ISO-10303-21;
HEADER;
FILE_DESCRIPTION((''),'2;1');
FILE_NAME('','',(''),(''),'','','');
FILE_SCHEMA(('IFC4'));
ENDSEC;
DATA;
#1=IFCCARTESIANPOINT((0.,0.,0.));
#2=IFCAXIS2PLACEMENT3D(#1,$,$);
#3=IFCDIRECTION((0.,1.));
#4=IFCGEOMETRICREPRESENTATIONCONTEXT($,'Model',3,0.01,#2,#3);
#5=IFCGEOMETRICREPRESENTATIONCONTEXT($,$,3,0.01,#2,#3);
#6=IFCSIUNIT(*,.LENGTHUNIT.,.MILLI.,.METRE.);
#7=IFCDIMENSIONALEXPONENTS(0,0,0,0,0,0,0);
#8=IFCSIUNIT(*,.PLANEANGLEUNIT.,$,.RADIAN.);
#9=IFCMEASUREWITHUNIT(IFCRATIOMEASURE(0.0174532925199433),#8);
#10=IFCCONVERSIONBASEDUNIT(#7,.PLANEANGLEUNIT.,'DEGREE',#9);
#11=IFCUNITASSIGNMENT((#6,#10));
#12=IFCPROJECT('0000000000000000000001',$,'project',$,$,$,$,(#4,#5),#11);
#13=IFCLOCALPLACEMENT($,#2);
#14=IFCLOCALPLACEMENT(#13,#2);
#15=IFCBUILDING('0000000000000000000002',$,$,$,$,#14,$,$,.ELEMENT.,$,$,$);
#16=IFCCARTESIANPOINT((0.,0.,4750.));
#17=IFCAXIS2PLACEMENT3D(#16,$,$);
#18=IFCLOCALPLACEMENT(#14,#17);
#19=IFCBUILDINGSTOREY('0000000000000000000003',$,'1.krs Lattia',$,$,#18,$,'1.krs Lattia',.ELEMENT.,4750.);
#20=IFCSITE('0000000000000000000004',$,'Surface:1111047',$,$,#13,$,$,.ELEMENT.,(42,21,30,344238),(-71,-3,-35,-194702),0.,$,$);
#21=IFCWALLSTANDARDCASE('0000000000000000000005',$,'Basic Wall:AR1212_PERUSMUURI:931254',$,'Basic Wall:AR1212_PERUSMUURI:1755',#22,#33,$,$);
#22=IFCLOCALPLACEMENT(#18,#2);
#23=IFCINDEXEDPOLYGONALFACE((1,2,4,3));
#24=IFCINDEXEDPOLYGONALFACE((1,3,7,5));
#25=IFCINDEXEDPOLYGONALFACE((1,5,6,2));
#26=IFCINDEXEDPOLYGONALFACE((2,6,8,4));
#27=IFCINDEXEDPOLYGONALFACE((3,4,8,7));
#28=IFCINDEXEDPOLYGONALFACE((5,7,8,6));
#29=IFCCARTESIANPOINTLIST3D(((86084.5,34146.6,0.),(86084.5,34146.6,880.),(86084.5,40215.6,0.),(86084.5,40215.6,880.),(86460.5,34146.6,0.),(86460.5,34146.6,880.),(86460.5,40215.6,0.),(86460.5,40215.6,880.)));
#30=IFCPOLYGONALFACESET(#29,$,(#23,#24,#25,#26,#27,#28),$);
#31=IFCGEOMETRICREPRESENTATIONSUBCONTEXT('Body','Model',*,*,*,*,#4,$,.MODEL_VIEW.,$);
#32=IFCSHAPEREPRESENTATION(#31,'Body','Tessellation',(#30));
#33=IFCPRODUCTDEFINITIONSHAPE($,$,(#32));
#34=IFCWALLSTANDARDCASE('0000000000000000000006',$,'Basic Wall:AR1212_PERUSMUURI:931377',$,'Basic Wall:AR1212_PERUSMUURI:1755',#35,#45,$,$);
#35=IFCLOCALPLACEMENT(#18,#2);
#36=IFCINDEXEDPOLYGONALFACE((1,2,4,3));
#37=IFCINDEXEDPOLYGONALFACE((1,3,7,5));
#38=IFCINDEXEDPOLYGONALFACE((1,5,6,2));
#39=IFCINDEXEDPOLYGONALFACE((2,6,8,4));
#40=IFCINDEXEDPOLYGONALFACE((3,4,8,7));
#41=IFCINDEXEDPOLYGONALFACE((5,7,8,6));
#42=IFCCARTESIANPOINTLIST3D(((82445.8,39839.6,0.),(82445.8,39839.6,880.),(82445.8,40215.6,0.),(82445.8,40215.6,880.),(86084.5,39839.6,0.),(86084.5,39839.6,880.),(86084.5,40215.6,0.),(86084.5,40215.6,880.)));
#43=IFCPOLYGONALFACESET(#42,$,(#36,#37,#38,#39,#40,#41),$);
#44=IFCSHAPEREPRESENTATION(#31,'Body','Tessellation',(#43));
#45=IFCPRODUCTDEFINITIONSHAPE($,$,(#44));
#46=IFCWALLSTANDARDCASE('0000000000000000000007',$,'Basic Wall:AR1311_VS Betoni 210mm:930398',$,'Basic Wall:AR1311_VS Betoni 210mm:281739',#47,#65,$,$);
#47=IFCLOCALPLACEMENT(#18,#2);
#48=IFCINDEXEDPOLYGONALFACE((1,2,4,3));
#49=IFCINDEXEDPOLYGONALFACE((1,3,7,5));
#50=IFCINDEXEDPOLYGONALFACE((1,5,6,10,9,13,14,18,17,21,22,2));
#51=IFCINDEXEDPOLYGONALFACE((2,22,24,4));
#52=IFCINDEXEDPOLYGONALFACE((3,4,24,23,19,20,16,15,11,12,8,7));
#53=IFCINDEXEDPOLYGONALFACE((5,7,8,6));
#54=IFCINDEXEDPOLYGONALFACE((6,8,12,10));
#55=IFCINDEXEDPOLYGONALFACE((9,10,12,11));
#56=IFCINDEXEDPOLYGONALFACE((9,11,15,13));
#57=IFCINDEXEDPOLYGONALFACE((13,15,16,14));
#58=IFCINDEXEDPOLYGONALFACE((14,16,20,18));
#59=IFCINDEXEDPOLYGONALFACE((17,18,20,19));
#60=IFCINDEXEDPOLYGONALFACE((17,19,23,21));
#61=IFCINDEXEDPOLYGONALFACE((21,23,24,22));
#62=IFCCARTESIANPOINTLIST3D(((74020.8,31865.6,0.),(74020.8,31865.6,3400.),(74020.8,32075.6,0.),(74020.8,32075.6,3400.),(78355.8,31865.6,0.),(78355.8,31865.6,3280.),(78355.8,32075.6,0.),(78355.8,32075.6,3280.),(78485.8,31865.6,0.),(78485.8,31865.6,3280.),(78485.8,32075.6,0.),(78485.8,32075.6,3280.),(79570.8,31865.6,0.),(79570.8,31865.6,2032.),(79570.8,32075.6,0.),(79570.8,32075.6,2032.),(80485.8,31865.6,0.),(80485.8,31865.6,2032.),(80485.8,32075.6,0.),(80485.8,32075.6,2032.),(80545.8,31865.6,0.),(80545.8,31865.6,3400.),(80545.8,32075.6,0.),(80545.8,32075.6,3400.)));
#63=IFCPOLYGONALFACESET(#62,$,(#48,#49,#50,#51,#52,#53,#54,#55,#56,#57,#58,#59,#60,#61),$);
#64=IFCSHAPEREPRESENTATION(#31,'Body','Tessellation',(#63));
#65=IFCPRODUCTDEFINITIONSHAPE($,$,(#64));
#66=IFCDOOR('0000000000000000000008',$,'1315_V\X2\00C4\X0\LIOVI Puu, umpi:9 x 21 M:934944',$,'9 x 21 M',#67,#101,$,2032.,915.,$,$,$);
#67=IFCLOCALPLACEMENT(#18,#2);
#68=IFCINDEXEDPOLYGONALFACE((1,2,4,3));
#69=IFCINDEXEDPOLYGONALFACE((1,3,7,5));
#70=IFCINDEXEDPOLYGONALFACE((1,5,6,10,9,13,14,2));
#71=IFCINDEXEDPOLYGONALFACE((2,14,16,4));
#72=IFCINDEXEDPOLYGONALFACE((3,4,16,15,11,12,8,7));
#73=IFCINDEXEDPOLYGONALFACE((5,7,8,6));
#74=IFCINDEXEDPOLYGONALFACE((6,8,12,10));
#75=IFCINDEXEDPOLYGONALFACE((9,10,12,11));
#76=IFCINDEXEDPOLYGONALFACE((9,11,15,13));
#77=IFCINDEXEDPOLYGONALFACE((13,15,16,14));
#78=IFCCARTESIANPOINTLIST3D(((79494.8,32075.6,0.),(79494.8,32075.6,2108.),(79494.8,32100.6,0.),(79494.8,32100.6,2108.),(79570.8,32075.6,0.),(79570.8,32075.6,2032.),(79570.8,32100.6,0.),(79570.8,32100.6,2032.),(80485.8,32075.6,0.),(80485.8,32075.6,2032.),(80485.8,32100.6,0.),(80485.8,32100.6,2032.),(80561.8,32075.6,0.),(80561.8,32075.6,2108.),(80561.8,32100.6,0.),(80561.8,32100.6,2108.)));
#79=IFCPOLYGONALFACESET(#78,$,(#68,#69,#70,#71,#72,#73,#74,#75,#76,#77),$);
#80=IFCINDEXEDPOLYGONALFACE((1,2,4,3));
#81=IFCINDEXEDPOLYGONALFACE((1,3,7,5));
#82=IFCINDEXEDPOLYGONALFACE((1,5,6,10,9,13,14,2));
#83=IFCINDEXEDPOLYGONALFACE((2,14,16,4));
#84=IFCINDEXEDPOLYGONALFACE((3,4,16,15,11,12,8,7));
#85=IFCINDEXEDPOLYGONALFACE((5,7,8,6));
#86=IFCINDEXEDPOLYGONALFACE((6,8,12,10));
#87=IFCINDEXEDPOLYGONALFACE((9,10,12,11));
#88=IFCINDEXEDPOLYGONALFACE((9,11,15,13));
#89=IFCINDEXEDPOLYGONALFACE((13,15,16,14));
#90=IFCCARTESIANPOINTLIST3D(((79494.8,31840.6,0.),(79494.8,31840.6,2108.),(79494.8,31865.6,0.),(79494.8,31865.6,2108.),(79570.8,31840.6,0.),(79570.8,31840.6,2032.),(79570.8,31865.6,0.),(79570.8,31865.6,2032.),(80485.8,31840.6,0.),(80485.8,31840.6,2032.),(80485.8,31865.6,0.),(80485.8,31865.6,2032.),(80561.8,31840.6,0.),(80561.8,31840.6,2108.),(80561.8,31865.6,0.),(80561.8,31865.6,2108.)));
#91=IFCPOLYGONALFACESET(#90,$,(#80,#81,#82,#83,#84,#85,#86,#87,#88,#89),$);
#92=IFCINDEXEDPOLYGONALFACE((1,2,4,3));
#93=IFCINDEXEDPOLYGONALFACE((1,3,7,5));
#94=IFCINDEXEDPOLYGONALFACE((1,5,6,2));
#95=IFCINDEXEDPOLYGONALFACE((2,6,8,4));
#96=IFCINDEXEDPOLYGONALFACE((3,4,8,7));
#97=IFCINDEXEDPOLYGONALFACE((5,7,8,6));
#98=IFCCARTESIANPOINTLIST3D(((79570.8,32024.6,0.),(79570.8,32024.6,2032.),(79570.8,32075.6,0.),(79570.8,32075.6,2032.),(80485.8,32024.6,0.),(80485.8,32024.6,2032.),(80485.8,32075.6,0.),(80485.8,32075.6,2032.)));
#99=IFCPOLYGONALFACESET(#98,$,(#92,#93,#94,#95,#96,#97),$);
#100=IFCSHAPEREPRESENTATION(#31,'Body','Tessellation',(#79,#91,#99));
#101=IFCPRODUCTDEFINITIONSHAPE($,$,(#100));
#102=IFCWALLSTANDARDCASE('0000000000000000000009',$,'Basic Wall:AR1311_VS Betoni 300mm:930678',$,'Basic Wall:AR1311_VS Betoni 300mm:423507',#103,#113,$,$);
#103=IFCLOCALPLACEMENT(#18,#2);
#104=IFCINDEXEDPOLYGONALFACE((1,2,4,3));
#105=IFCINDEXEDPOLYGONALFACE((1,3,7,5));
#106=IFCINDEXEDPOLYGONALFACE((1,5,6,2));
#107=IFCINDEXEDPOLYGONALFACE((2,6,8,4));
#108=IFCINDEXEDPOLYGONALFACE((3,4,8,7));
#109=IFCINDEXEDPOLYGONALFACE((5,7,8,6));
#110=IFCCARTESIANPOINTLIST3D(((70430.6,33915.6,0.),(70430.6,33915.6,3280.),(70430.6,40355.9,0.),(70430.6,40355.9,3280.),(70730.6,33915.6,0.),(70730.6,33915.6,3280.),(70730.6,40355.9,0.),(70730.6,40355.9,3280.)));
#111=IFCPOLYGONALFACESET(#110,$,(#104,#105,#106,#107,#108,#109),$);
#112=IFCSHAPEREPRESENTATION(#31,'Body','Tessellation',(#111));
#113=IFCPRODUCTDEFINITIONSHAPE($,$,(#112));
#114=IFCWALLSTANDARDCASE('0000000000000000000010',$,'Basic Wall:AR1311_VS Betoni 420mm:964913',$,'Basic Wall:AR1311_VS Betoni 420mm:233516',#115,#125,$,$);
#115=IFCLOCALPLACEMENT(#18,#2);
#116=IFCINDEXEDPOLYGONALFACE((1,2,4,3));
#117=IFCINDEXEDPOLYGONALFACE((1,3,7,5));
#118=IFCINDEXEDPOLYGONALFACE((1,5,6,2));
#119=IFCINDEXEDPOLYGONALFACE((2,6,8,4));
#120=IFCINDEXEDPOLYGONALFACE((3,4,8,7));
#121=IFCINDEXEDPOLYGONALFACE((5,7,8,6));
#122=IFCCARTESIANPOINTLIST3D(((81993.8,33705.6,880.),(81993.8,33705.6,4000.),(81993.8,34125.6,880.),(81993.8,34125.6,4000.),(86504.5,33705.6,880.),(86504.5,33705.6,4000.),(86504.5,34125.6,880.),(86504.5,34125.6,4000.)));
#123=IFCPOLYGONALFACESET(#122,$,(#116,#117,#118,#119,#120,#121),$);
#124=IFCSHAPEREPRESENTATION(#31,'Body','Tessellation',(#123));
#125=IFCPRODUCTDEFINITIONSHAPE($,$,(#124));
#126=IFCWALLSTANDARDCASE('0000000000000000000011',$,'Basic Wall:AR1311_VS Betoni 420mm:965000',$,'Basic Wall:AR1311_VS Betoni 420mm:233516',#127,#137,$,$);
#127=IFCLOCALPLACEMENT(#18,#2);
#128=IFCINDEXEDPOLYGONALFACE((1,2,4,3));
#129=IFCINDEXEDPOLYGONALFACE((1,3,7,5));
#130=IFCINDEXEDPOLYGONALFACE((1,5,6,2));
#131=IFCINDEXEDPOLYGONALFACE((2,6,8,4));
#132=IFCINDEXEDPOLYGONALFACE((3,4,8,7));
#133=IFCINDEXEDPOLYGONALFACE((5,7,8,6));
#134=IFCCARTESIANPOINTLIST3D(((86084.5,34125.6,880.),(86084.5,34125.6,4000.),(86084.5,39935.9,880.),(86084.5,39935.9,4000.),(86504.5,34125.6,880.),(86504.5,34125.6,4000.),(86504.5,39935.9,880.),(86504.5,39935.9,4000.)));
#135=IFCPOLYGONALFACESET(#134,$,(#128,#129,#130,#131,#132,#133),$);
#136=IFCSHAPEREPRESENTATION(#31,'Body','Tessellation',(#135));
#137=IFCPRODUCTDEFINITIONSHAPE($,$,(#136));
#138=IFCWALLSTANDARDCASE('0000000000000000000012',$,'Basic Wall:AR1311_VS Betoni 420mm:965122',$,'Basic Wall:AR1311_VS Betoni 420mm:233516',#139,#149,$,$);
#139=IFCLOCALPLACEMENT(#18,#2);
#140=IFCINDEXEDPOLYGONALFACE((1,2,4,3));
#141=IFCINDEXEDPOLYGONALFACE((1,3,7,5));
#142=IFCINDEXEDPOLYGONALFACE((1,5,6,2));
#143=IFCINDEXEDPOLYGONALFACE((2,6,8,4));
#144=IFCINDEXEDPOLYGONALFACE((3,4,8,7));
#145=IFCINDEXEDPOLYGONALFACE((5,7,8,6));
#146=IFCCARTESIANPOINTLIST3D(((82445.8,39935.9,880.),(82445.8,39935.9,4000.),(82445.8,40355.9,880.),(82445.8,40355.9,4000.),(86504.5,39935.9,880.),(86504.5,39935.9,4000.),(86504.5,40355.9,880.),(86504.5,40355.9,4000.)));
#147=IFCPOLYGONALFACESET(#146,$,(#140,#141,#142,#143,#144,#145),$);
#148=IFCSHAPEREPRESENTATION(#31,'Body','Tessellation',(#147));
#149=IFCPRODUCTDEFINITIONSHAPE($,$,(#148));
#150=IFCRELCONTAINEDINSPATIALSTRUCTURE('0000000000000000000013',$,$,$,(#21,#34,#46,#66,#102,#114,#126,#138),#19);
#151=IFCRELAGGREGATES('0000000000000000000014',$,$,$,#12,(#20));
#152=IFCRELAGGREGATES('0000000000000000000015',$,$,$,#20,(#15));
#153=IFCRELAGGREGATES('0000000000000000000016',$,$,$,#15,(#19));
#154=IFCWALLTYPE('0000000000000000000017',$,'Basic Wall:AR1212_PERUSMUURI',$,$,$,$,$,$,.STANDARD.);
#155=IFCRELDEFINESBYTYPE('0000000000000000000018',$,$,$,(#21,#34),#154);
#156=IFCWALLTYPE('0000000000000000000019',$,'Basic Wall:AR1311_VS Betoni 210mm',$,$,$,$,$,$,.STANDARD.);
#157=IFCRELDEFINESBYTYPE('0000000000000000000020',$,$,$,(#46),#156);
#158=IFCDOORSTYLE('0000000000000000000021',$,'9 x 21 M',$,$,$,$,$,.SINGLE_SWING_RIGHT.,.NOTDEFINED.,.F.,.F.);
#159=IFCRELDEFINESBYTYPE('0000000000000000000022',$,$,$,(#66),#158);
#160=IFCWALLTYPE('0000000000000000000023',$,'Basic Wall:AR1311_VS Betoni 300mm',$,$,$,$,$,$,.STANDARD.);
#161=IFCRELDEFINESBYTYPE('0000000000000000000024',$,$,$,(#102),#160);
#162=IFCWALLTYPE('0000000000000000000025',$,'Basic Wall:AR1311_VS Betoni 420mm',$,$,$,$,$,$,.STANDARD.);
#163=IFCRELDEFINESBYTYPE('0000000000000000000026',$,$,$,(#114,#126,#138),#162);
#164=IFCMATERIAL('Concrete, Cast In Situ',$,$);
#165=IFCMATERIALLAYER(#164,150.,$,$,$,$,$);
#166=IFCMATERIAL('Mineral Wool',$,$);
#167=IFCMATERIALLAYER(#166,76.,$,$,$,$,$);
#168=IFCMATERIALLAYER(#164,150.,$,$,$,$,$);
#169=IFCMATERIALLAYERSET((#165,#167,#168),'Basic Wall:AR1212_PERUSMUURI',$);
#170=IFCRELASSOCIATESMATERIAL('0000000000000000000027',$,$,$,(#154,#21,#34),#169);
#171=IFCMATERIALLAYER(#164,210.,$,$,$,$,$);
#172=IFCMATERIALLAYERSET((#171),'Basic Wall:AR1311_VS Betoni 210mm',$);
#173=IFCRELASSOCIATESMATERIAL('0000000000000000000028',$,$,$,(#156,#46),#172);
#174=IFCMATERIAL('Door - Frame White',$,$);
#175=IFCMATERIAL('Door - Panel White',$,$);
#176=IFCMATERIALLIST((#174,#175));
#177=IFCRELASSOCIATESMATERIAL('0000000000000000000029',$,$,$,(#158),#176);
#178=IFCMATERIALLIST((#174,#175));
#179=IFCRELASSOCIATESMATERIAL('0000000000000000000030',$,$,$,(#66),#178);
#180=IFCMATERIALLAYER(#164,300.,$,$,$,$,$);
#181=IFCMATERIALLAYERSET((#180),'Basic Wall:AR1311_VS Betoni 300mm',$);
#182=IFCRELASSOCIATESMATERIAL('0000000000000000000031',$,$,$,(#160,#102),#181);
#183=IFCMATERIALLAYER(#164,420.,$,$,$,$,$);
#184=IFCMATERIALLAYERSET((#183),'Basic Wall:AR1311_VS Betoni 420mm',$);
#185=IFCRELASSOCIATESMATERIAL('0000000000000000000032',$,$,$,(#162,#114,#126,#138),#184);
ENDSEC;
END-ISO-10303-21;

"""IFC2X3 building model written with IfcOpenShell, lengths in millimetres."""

from ifc_helpers import new_model, entity, si_unit, converted_unit, direction, frame, frame_2d, origin, place, context, subcontext, project, spatial, polyline, rectangle, outline, extrude, clip, bounded_halfspace, source, transform, mapped, material, material_list, layer, layer_set, layer_usage, type_object, type_shapes, element, fill, save


model = new_model("IFC2X3")

# Units and contexts
model_context = context("Model", 3, precision=0.01, world=origin(), true_north=direction((0.0, 1.0)))
context_of_model = context(None, 3, precision=0.01, world=origin(), true_north=direction((0.0, 1.0)))
body_context = subcontext(model_context, "Body", "Model", "MODEL_VIEW")
ifc_project = project(units=[si_unit("LENGTHUNIT", "METRE", prefix="MILLI"), converted_unit("PLANEANGLEUNIT", "DEGREE", entity("IfcRatioMeasure", 0.0174532925199433), si_unit("PLANEANGLEUNIT", "RADIAN"), dimensions=[0, 0, 0, 0, 0, 0, 0])], contexts=[model_context, context_of_model])

# Site, building, storey
site_placement = place(None, origin())
site = spatial("IfcSite", under=ifc_project, at=site_placement, Name="Surface:1111047", CompositionType="ELEMENT", RefLatitude=(42, 21, 30, 344238), RefLongitude=(-71, -3, -35, -194702), RefElevation=0.0)
building_placement = place(site_placement, origin())
building = spatial("IfcBuilding", under=site, at=building_placement, CompositionType="ELEMENT")
storey_placement = place(building_placement, frame((0.0, 0.0, 4750.0)))
storey = spatial("IfcBuildingStorey", under=building, at=storey_placement, Name="1.krs Lattia", LongName="1.krs Lattia", CompositionType="ELEMENT", Elevation=4750.0)

# Walls
ifc_material_1 = material(Name="Concrete, Cast In Situ")
ifc_layer_1 = layer(ifc_material_1, 150.0)
ifc_material_2 = material(Name="Mineral Wool")
ifc_layer_2 = layer(ifc_material_2, 76.0)
ifc_layer_3 = layer(ifc_material_1, 150.0)
ifc_layer_set_1 = layer_set([ifc_layer_1, ifc_layer_2, ifc_layer_3], Name="Basic Wall:AR1212_PERUSMUURI")
wall_type_1 = type_object("IfcWallType", Name="Basic Wall:AR1212_PERUSMUURI", PredefinedType="STANDARD", material=ifc_layer_set_1)
ifc_layer_usage_1 = layer_usage(ifc_layer_set_1, "AXIS2", "NEGATIVE", 188.0)
wall_1_placement = place(storey_placement, frame((86272.5, 34146.6, 0.0), z_axis=(0.0, 0.0, 1.0), x_axis=(0.0, 1.0, 0.0)))
element("IfcWallStandardCase", 1, at=wall_1_placement, inside=storey, type_object=wall_type_1, material=ifc_layer_usage_1, Name="Basic Wall:AR1212_PERUSMUURI:931254", ObjectType="Basic Wall:AR1212_PERUSMUURI:1755", context=body_context, shape_type="SweptSolid", body=[
    extrude(rectangle(XDim=6069.0, YDim=376.0, at=frame_2d((3034.5, 0.0), x_axis=(-1.0, 0.0))), origin(), (0.0, 0.0, 1.0), 880.0),
])
ifc_layer_usage_2 = layer_usage(ifc_layer_set_1, "AXIS2", "NEGATIVE", 188.0)
wall_2_placement = place(storey_placement, frame((86084.5, 40027.6, 0.0), z_axis=(0.0, 0.0, 1.0), x_axis=(-1.0, 0.0, 0.0)))
element("IfcWallStandardCase", 2, at=wall_2_placement, inside=storey, type_object=wall_type_1, material=ifc_layer_usage_2, Name="Basic Wall:AR1212_PERUSMUURI:931377", ObjectType="Basic Wall:AR1212_PERUSMUURI:1755", context=body_context, shape_type="SweptSolid", body=[
    extrude(rectangle(XDim=3638.7, YDim=376.0, at=frame_2d((1819.3, 0.0), x_axis=(-1.0, 0.0))), origin(), (0.0, 0.0, 1.0), 880.0),
])

# Wall, opening, door
ifc_layer_4 = layer(ifc_material_1, 210.0)
ifc_layer_set_2 = layer_set([ifc_layer_4], Name="Basic Wall:AR1311_VS Betoni 210mm")
ifc_layer_usage_3 = layer_usage(ifc_layer_set_2, "AXIS2", "NEGATIVE", 105.0)
wall_type_2 = type_object("IfcWallType", Name="Basic Wall:AR1311_VS Betoni 210mm", PredefinedType="STANDARD", material=ifc_layer_set_2)
wall_3_placement = place(storey_placement, frame((74020.8, 31970.6, 0.0)))
wall_3 = element("IfcWallStandardCase", 3, at=wall_3_placement, inside=storey, type_object=wall_type_2, material=ifc_layer_usage_3, Name="Basic Wall:AR1311_VS Betoni 210mm:930398", ObjectType="Basic Wall:AR1311_VS Betoni 210mm:281739", context=body_context, shape_type="Clipping", body=[
    clip(extrude(rectangle(XDim=6525.0, YDim=210.0, at=frame_2d((3262.5, 0.0), x_axis=(-1.0, 0.0))), origin(), (0.0, 0.0, 1.0), 3400.0), bounded_halfspace(frame((4465.0, 105.0, 3280.0), z_axis=(0.0, 0.0, -1.0), x_axis=(0.0, 1.0, 0.0)), False, frame((4465.0, 105.0, 3280.0), z_axis=(0.0, 0.0, -1.0), x_axis=(0.0, 1.0, 0.0)), polyline([(0.0, 0.0), (-210.0, 0.0), (-210.0, -130.0), (0.0, -130.0), (0.0, 0.0)]))),
])
opening_1_placement = place(wall_3_placement, frame((5550.0, -105.0, 0.0)))
opening_1 = element("IfcOpeningElement", 4, at=opening_1_placement, cuts=wall_3, ObjectType="Opening", context=body_context, shape_type="SweptSolid", body=[
    extrude(rectangle(XDim=915.0, YDim=2032.0, at=frame_2d((1016.0, 457.5), x_axis=(0.0, 1.0))), frame((0.0, 0.0, 0.0), z_axis=(0.0, 1.0, 0.0), x_axis=(0.0, 0.0, 1.0)), (0.0, 0.0, 1.0), 210.0),
])
ifc_material_3 = material(Name="Door - Frame White")
ifc_material_4 = material(Name="Door - Panel White")
ifc_material_list_1 = material_list([ifc_material_3, ifc_material_4])
ifc_material_list_2 = material_list([ifc_material_3, ifc_material_4])
door_style_1 = type_object("IfcDoorStyle", Name="9 x 21 M", ConstructionType="NOTDEFINED", OperationType="SINGLE_SWING_RIGHT", ParameterTakesPrecedence=False, Sizeable=False, material=ifc_material_list_2)
shared_shape_1 = source(origin(), body_context, "Body", "SweptSolid", [
    extrude(outline(polyline([(-533.5, -1073.0), (533.5, -1073.0), (533.5, 1035.0), (457.5, 1035.0), (457.5, -997.0), (-457.5, -997.0), (-457.5, 1035.0), (-533.5, 1035.0), (-533.5, -1073.0)])), frame((457.5, 210.0, 1035.0), z_axis=(0.0, 1.0, 0.0), x_axis=(1.0, 0.0, 0.0)), (0.0, 0.0, 1.0), 25.0),
    extrude(outline(polyline([(-1073.0, -533.5), (1035.0, -533.5), (1035.0, -457.5), (-997.0, -457.5), (-997.0, 457.5), (1035.0, 457.5), (1035.0, 533.5), (-1073.0, 533.5), (-1073.0, -533.5)])), frame((457.5, -25.0, 1035.0), z_axis=(0.0, 1.0, 0.0), x_axis=(0.0, 0.0, -1.0)), (0.0, 0.0, 1.0), 25.0),
    extrude(rectangle(XDim=51.0, YDim=915.0, at=frame_2d((0.0, 0.0), x_axis=(1.0, 0.0))), frame((457.5, 184.5, 0.0), z_axis=(0.0, 0.0, 1.0), x_axis=(0.0, 1.0, 0.0)), (0.0, 0.0, 1.0), 2032.0),
])
type_shapes(door_style_1, [shared_shape_1])
door_1_placement = place(opening_1_placement, origin())
door_1 = element("IfcDoor", 5, at=door_1_placement, inside=storey, type_object=door_style_1, material=ifc_material_list_1, Name="1315_VÄLIOVI Puu, umpi:9 x 21 M:934944", ObjectType="9 x 21 M", OverallHeight=2032.0, OverallWidth=915.0, context=body_context, shape_type="MappedRepresentation", body=[
    mapped(shared_shape_1, transform((0.0, 0.0, 0.0), scale=1.0)),
])
fill(opening_1, door_1)

# Walls
ifc_layer_5 = layer(ifc_material_1, 300.0)
ifc_layer_set_3 = layer_set([ifc_layer_5], Name="Basic Wall:AR1311_VS Betoni 300mm")
ifc_layer_usage_4 = layer_usage(ifc_layer_set_3, "AXIS2", "NEGATIVE", 150.0)
wall_type_3 = type_object("IfcWallType", Name="Basic Wall:AR1311_VS Betoni 300mm", PredefinedType="STANDARD", material=ifc_layer_set_3)
wall_4_placement = place(storey_placement, frame((70580.6, 40355.9, 0.0), z_axis=(0.0, 0.0, 1.0), x_axis=(0.0, -1.0, 0.0)))
element("IfcWallStandardCase", 6, at=wall_4_placement, inside=storey, type_object=wall_type_3, material=ifc_layer_usage_4, Name="Basic Wall:AR1311_VS Betoni 300mm:930678", ObjectType="Basic Wall:AR1311_VS Betoni 300mm:423507", context=body_context, shape_type="Clipping", body=[
    clip(extrude(rectangle(XDim=6440.3, YDim=300.0, at=frame_2d((3220.2, 0.0), x_axis=(-1.0, 0.0))), origin(), (0.0, 0.0, 1.0), 3280.0), bounded_halfspace(frame((0.0, -150.0, 3280.0), z_axis=(0.0, 0.0, -1.0), x_axis=(0.0, -1.0, 0.0)), True, frame((0.0, -150.0, 3280.0)), polyline([(0.0, 0.0), (6440.3, 0.0), (6440.3, 300.0), (6020.3, 300.0), (420.0, 300.0), (0.0, 300.0), (0.0, 0.0)]))),
])
ifc_layer_6 = layer(ifc_material_1, 420.0)
ifc_layer_set_4 = layer_set([ifc_layer_6], Name="Basic Wall:AR1311_VS Betoni 420mm")
wall_type_4 = type_object("IfcWallType", Name="Basic Wall:AR1311_VS Betoni 420mm", PredefinedType="STANDARD", material=ifc_layer_set_4)
ifc_layer_usage_5 = layer_usage(ifc_layer_set_4, "AXIS2", "NEGATIVE", 210.0)
wall_5_placement = place(storey_placement, frame((81993.8, 33915.6, 880.0)))
element("IfcWallStandardCase", 7, at=wall_5_placement, inside=storey, type_object=wall_type_4, material=ifc_layer_usage_5, Name="Basic Wall:AR1311_VS Betoni 420mm:964913", ObjectType="Basic Wall:AR1311_VS Betoni 420mm:233516", context=body_context, shape_type="SweptSolid", body=[
    extrude(rectangle(XDim=4510.7, YDim=420.0, at=frame_2d((2255.3, 0.0), x_axis=(-1.0, 0.0))), origin(), (0.0, 0.0, 1.0), 3120.0),
])
ifc_layer_usage_6 = layer_usage(ifc_layer_set_4, "AXIS2", "NEGATIVE", 210.0)
wall_6_placement = place(storey_placement, frame((86294.5, 34125.6, 880.0), z_axis=(0.0, 0.0, 1.0), x_axis=(0.0, 1.0, 0.0)))
element("IfcWallStandardCase", 8, at=wall_6_placement, inside=storey, type_object=wall_type_4, material=ifc_layer_usage_6, Name="Basic Wall:AR1311_VS Betoni 420mm:965000", ObjectType="Basic Wall:AR1311_VS Betoni 420mm:233516", context=body_context, shape_type="SweptSolid", body=[
    extrude(rectangle(XDim=5810.3, YDim=420.0, at=frame_2d((2905.2, 0.0), x_axis=(-1.0, 0.0))), origin(), (0.0, 0.0, 1.0), 3120.0),
])
ifc_layer_usage_7 = layer_usage(ifc_layer_set_4, "AXIS2", "NEGATIVE", 210.0)
wall_7_placement = place(storey_placement, frame((86504.5, 40145.9, 880.0), z_axis=(0.0, 0.0, 1.0), x_axis=(-1.0, 0.0, 0.0)))
element("IfcWallStandardCase", 9, at=wall_7_placement, inside=storey, type_object=wall_type_4, material=ifc_layer_usage_7, Name="Basic Wall:AR1311_VS Betoni 420mm:965122", ObjectType="Basic Wall:AR1311_VS Betoni 420mm:233516", context=body_context, shape_type="SweptSolid", body=[
    extrude(rectangle(XDim=4058.7, YDim=420.0, at=frame_2d((2029.3, 0.0), x_axis=(-1.0, 0.0))), origin(), (0.0, 0.0, 1.0), 3120.0),
])

save(model, "model.ifc")
